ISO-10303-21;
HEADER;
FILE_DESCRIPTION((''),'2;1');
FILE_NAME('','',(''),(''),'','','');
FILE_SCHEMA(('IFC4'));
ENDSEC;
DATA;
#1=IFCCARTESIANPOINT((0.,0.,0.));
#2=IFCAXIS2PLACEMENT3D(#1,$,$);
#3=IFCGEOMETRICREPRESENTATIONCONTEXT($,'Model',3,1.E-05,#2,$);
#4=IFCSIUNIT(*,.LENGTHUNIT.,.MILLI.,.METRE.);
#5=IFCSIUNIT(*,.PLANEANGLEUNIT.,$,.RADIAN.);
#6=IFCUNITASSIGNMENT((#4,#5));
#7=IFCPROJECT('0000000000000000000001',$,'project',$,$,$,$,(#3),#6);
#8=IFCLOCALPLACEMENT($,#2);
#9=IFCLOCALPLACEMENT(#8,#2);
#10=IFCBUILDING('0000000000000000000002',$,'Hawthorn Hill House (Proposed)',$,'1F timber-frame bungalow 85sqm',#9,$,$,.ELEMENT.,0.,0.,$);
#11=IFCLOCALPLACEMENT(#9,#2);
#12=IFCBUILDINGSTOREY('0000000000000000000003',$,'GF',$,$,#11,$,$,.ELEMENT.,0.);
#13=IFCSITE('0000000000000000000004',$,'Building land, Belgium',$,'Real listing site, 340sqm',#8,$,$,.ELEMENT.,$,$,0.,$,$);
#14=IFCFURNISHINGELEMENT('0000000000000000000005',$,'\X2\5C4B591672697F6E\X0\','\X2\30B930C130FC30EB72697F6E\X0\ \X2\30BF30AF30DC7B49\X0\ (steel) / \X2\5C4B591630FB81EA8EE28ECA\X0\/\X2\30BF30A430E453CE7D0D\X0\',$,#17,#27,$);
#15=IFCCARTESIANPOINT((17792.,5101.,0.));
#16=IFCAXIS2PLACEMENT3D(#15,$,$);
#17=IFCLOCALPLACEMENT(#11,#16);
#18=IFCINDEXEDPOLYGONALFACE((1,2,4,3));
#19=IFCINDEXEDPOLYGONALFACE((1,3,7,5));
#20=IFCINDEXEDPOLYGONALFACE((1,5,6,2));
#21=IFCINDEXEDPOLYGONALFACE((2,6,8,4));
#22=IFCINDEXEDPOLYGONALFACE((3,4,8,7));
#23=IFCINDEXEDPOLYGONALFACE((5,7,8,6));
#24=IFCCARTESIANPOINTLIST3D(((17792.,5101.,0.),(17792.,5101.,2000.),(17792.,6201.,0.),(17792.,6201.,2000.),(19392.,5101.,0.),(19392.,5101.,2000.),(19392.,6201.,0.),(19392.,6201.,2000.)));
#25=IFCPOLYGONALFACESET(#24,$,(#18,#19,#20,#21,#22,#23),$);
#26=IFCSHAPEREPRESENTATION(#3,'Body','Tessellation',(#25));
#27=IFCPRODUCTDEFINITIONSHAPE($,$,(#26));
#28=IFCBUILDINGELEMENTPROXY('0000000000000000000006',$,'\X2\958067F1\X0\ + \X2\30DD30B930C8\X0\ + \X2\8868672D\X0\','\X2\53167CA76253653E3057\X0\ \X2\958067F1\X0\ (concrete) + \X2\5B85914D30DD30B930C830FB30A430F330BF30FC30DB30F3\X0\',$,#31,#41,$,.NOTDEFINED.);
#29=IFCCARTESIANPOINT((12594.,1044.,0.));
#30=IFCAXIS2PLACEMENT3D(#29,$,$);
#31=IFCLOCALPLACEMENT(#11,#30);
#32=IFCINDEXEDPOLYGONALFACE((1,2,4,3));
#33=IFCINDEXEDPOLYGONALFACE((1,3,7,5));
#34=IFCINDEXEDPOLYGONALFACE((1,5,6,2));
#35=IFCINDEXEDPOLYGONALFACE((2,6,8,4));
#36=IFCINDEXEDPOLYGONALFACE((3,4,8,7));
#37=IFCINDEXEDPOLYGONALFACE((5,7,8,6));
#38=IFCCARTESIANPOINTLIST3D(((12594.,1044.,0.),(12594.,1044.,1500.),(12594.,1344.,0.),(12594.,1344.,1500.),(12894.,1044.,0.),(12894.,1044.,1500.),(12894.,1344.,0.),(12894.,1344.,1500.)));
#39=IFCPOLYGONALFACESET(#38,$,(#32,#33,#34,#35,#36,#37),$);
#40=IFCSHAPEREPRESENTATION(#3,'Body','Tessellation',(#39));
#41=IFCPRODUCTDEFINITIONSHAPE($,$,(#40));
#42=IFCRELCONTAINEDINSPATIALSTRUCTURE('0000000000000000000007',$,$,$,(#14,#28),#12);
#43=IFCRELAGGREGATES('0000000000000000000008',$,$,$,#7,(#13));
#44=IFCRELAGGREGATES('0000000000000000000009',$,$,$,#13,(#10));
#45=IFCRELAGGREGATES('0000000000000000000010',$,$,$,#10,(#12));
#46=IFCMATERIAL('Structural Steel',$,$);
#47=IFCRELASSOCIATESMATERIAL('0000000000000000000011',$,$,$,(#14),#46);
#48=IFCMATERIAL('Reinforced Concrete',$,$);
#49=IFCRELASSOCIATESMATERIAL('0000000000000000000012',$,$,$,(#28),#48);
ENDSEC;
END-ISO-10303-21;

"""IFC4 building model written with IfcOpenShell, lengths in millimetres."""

from ifc_helpers import new_model, si_unit, frame, frame_2d, origin, place, context, project, spatial, rectangle, extrude, material, element, save


model = new_model("IFC4")

# Units and contexts
model_context = context("Model", 3, precision=1e-05, world=origin())
ifc_project = project(units=[si_unit("LENGTHUNIT", "METRE", prefix="MILLI"), si_unit("PLANEANGLEUNIT", "RADIAN")], contexts=[model_context])

# Site, building, storey
site_placement = place(None, origin())
site = spatial("IfcSite", under=ifc_project, at=site_placement, Name="Building land, Belgium", ObjectType="Real listing site, 340sqm", CompositionType="ELEMENT", RefElevation=0.0)
building_placement = place(site_placement, origin())
building = spatial("IfcBuilding", under=site, at=building_placement, Name="Hawthorn Hill House (Proposed)", ObjectType="1F timber-frame bungalow 85sqm", CompositionType="ELEMENT", ElevationOfRefHeight=0.0, ElevationOfTerrain=0.0)
storey_placement = place(building_placement, origin())
storey = spatial("IfcBuildingStorey", under=building, at=storey_placement, Name="GF", CompositionType="ELEMENT", Elevation=0.0)

# Shared definitions
ifc_material_1 = material(Name="Reinforced Concrete")

# Shared definitions
ifc_material_2 = material(Name="Structural Steel")

# Furnishing element
furnishing_1_placement = place(storey_placement, frame((17792.0, 5101.0, 0.0)))
element("IfcFurnishingElement", 1, at=furnishing_1_placement, inside=storey, material=ifc_material_2, Name="屋外物置", Description="スチール物置 タクボ等 (steel) / 屋外・自転車/タイヤ収納", context=model_context, shape_type="SweptSolid", body=[
    extrude(rectangle(XDim=1600.0, YDim=1100.0, at=frame_2d((800.0, 550.0))), frame((17792.0, 5101.0, 0.0)), (0.0, 0.0, 1.0), 2000.0),
])

# Building element proxy
proxy_placement = place(storey_placement, frame((12594.0, 1044.0, 0.0)))
element("IfcBuildingElementProxy", 2, at=proxy_placement, inside=storey, material=ifc_material_1, Name="門柱 + ポスト + 表札", Description="化粧打放し 門柱 (concrete) + 宅配ポスト・インターホン", PredefinedType="NOTDEFINED", context=model_context, shape_type="SweptSolid", body=[
    extrude(rectangle(XDim=300.0, YDim=300.0, at=frame_2d((150.0, 150.0))), frame((12594.0, 1044.0, 0.0)), (0.0, 0.0, 1.0), 1500.0),
])

save(model, "model.ifc")
